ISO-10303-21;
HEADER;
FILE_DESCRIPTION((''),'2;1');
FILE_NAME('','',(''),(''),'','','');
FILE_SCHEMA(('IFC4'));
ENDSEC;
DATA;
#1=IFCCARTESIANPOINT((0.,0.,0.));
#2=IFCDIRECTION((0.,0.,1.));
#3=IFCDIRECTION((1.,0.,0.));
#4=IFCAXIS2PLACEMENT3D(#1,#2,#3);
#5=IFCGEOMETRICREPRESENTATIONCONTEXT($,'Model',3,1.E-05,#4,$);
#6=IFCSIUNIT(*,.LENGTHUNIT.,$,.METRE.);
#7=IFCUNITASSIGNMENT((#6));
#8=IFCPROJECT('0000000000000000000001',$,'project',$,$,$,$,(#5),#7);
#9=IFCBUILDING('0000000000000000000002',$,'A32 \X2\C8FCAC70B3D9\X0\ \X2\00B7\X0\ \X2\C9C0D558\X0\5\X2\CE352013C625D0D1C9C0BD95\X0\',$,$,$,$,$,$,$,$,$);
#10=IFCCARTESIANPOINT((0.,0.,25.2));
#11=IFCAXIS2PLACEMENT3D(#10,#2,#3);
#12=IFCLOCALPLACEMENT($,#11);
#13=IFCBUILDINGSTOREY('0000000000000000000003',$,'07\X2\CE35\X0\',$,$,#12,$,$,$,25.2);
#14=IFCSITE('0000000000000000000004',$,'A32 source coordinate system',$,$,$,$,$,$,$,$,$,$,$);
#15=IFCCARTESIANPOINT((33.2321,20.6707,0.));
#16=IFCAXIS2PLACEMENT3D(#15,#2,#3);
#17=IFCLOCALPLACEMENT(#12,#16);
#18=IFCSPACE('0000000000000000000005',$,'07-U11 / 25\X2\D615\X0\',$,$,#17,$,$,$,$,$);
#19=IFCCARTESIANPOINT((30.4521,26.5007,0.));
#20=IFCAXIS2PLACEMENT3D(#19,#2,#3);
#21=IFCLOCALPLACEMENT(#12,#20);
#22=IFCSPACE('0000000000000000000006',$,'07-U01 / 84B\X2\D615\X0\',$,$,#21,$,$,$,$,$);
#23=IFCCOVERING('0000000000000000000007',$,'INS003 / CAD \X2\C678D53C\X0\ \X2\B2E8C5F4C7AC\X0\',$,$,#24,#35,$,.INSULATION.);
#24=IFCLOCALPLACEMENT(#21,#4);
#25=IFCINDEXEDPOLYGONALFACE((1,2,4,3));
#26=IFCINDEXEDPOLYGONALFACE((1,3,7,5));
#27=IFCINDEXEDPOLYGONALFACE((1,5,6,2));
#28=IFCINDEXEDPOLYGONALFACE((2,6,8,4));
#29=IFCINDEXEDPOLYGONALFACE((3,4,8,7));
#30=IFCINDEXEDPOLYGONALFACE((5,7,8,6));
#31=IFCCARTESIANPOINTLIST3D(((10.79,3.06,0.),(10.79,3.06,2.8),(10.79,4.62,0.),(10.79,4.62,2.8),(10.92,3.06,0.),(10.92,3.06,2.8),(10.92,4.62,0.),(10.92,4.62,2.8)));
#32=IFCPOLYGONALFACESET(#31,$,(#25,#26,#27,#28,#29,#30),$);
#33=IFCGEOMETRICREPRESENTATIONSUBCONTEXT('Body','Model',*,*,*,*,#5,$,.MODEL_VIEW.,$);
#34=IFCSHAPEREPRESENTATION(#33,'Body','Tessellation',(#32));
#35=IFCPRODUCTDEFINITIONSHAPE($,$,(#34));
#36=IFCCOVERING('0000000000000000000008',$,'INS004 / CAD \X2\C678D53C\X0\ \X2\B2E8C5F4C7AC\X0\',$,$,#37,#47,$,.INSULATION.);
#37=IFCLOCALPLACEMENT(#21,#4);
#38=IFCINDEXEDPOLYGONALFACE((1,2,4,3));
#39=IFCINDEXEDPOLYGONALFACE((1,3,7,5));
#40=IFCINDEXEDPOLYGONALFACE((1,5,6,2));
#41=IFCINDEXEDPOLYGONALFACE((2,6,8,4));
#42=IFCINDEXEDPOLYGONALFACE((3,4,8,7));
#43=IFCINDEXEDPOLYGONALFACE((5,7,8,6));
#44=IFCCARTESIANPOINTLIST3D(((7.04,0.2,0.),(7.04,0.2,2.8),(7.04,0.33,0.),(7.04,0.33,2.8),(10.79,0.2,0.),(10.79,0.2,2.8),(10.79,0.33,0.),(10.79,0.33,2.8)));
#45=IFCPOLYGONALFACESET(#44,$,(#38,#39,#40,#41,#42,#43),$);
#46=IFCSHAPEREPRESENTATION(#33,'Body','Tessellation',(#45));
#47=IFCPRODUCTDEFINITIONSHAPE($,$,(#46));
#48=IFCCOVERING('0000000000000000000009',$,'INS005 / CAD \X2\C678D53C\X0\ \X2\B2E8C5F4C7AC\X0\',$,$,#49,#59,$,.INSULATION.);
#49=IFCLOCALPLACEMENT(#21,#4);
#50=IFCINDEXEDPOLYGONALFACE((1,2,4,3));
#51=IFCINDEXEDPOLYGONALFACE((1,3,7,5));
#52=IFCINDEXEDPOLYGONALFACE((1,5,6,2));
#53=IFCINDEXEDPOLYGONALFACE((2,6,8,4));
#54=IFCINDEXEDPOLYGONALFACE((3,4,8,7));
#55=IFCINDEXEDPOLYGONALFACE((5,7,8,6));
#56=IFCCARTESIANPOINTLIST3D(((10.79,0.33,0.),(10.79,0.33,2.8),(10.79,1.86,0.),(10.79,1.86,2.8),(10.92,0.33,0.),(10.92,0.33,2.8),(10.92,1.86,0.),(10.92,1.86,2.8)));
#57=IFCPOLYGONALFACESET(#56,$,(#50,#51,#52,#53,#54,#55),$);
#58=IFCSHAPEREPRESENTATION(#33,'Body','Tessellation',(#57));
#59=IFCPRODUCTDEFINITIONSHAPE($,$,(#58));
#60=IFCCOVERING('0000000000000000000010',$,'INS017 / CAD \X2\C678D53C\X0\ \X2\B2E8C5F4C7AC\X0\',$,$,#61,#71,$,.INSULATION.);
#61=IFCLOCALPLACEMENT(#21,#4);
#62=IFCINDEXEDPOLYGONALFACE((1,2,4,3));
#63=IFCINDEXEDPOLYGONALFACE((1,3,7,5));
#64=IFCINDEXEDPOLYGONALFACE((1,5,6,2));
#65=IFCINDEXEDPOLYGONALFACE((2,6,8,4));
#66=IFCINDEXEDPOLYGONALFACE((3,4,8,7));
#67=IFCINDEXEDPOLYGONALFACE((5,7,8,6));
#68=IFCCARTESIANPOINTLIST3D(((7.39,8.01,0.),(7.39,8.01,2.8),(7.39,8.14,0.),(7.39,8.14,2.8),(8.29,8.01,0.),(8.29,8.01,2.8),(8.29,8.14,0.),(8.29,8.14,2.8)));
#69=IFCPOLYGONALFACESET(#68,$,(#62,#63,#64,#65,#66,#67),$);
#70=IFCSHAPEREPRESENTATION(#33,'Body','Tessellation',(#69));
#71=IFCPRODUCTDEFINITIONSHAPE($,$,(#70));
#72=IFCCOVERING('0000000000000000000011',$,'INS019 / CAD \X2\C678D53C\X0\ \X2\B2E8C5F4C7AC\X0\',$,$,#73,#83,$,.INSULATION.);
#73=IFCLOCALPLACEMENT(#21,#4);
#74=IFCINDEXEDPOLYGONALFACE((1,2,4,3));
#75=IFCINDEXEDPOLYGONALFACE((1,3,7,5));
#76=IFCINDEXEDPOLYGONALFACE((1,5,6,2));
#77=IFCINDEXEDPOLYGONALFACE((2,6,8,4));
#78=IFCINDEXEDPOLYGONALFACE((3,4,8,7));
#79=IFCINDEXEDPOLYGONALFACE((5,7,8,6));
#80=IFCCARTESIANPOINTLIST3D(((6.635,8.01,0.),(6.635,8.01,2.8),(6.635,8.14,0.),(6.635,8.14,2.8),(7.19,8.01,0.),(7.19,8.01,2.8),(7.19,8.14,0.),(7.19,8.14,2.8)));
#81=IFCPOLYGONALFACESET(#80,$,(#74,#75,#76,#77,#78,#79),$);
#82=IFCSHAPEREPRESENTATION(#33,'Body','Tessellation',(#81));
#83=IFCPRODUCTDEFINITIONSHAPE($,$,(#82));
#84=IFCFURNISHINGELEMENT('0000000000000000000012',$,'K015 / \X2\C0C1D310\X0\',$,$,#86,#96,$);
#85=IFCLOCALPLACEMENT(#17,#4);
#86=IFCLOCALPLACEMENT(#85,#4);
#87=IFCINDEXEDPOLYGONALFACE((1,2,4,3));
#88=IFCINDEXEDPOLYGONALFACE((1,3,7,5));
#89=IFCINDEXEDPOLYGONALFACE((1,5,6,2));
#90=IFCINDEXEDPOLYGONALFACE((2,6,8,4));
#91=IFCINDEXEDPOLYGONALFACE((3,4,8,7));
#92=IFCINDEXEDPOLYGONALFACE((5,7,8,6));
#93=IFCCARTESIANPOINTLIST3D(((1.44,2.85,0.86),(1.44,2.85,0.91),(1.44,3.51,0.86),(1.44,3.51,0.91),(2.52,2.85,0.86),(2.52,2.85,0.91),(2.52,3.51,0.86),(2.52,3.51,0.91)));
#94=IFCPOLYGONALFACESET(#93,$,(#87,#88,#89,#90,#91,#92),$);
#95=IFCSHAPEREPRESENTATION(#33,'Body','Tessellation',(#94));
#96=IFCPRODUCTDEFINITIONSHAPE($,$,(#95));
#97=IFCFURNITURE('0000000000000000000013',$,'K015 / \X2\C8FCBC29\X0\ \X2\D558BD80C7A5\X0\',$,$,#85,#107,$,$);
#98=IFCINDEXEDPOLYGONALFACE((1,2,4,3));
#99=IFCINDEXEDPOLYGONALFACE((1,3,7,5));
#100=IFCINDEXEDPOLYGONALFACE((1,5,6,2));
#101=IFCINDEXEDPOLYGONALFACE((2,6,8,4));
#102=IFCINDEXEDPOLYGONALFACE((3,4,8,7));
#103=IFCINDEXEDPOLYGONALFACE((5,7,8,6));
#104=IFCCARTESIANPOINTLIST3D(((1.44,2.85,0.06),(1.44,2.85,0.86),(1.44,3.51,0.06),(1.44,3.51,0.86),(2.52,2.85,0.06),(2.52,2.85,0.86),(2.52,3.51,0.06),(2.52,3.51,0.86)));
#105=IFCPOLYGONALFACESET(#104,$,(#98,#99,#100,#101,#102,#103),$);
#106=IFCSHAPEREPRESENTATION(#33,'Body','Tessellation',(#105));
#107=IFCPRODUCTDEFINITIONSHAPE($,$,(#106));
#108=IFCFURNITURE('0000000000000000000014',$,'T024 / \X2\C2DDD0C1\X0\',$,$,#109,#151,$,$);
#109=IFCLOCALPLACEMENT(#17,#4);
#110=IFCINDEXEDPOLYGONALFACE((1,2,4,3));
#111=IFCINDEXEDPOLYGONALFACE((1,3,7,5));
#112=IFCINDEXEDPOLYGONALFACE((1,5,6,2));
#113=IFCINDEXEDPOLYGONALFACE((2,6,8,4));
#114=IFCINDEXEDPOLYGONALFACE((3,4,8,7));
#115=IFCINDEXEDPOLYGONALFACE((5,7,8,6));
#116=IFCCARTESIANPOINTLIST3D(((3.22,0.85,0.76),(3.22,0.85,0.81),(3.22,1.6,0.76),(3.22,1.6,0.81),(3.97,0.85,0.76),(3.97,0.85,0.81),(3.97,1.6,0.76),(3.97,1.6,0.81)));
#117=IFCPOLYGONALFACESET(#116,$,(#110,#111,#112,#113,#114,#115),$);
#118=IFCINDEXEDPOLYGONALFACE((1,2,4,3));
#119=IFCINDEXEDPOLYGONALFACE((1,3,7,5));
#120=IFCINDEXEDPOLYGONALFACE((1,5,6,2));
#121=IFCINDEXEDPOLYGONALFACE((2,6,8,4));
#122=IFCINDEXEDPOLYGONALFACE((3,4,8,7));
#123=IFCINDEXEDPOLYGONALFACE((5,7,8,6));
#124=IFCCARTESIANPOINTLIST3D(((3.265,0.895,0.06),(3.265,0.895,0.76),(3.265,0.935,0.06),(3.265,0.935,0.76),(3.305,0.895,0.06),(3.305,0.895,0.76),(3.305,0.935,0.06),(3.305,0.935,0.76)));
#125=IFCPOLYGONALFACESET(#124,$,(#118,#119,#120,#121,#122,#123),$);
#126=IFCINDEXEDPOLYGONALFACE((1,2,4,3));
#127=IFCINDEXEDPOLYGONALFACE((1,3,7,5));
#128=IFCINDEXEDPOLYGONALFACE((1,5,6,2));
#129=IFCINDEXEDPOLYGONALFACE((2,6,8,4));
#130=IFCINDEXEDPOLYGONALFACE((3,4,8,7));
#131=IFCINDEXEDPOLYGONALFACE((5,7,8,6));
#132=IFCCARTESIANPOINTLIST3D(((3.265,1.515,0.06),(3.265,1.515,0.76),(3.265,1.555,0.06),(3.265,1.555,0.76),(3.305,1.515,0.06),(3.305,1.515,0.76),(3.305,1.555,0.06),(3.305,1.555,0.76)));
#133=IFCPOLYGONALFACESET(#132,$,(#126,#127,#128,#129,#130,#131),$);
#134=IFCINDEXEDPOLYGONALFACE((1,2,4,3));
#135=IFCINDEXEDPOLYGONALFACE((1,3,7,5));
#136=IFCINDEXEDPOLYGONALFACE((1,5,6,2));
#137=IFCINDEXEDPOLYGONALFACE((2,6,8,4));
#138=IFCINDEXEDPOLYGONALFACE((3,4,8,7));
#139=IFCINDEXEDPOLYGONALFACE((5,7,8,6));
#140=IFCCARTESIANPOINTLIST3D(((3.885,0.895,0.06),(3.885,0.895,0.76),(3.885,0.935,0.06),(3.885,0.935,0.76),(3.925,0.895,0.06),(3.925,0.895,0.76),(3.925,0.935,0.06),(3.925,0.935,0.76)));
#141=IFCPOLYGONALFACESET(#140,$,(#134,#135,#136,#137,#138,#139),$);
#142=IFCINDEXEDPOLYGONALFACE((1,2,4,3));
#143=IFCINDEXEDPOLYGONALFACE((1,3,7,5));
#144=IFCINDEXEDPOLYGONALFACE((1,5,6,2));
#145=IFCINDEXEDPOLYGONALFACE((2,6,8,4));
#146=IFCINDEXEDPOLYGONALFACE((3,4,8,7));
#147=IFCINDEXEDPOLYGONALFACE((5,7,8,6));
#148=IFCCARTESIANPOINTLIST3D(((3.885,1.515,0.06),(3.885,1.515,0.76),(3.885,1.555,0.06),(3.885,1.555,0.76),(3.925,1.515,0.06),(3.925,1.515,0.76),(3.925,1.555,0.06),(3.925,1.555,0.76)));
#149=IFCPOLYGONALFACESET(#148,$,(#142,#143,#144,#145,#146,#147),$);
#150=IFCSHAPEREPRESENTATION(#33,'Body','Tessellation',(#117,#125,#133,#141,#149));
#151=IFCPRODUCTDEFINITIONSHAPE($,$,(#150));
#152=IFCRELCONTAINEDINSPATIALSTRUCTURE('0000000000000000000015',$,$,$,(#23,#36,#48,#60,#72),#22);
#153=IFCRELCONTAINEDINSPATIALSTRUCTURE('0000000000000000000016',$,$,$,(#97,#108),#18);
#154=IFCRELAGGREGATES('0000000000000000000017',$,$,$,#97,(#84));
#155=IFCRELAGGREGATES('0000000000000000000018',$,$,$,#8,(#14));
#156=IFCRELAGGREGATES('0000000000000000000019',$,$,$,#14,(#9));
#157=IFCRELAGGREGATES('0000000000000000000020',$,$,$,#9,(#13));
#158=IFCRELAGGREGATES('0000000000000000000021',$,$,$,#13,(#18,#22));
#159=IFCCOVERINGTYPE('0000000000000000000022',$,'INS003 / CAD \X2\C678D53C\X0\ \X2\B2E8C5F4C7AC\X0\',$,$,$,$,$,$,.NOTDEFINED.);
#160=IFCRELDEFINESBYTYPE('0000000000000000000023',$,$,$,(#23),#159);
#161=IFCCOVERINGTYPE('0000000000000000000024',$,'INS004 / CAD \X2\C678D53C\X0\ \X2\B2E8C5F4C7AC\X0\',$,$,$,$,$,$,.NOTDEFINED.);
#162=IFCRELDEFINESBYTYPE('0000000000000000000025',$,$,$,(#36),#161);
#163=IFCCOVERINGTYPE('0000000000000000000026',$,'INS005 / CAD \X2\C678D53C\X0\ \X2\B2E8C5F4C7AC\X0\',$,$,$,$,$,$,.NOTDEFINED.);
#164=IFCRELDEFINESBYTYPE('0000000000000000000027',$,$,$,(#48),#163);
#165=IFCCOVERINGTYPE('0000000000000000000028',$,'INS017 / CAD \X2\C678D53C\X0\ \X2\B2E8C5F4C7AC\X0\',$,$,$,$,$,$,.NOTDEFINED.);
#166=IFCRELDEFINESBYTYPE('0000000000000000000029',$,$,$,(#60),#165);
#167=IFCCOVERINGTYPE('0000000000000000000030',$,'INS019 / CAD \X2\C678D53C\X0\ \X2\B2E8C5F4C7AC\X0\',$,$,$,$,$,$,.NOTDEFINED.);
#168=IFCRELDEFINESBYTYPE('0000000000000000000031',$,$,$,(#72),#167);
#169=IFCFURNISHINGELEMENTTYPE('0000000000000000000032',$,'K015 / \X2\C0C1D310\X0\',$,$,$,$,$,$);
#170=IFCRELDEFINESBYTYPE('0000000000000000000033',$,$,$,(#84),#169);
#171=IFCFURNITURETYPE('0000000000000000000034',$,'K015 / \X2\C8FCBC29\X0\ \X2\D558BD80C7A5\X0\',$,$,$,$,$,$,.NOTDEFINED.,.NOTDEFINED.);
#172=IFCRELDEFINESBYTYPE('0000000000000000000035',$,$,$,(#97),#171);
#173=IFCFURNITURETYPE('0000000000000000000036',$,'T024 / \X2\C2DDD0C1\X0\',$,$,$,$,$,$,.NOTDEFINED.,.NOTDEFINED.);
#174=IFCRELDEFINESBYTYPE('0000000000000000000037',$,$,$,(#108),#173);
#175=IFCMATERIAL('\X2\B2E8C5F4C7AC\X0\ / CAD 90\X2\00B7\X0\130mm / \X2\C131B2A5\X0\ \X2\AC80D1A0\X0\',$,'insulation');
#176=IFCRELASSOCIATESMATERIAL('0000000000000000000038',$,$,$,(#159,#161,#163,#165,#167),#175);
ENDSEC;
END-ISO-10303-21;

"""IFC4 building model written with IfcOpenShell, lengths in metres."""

from ifc_helpers import new_model, si_unit, frame, origin, origin_with_axes, place, context, subcontext, project, spatial, polyline, outline, extrude, source, transform, mapped, material, type_object, type_shapes, element, aggregate, save


model = new_model("IFC4")

# Units and contexts
model_context = context("Model", 3, precision=1e-05, world=origin_with_axes())
body_context = subcontext(model_context, "Body", "Model", "MODEL_VIEW")
ifc_project = project(units=[si_unit("LENGTHUNIT", "METRE")], contexts=[model_context])

# Site, building, storey, space
site = spatial("IfcSite", under=ifc_project, Name="A32 source coordinate system")
building = spatial("IfcBuilding", under=site, Name="A32 주거동 · 지하5층–옥탑지붕")
storey_placement = place(None, frame((0.0, 0.0, 25.2), z_axis=(0.0, 0.0, 1.0), x_axis=(1.0, 0.0, 0.0)))
storey = spatial("IfcBuildingStorey", under=building, at=storey_placement, Name="07층", Elevation=25.2)
space_1_placement = place(storey_placement, frame((33.2321, 20.6707, 0.0), z_axis=(0.0, 0.0, 1.0), x_axis=(1.0, 0.0, 0.0)))
space_1 = spatial("IfcSpace", under=storey, at=space_1_placement, Name="07-U11 / 25형")

# Shared definitions
space_2_placement = place(storey_placement, frame((30.4521, 26.5007, 0.0), z_axis=(0.0, 0.0, 1.0), x_axis=(1.0, 0.0, 0.0)))
space_2 = spatial("IfcSpace", under=storey, at=space_2_placement, Name="07-U01 / 84B형")

# Coverings
ifc_material = material(Name="단열재 / CAD 90·130mm / 성능 검토", Category="insulation")
covering_type_1 = type_object("IfcCoveringType", Name="INS003 / CAD 외피 단열재", PredefinedType="NOTDEFINED", material=ifc_material)
shared_shape_1 = source(origin(), body_context, "Body", "SweptSolid", [
    extrude(outline(polyline([(10.79, 3.06), (10.79, 4.62), (10.92, 4.62), (10.92, 3.06), (10.79, 3.06)])), origin(), (0.0, 0.0, 1.0), 2.8),
])
type_shapes(covering_type_1, [shared_shape_1])
covering_1_placement = place(space_2_placement, origin_with_axes())
element("IfcCovering", 1, at=covering_1_placement, inside=space_2, type_object=covering_type_1, Name="INS003 / CAD 외피 단열재", PredefinedType="INSULATION", context=body_context, shape_type="MappedRepresentation", body=[
    mapped(shared_shape_1, transform((0.0, 0.0, 0.0), scale=1.0)),
])
covering_type_2 = type_object("IfcCoveringType", Name="INS004 / CAD 외피 단열재", PredefinedType="NOTDEFINED", material=ifc_material)
shared_shape_2 = source(origin(), body_context, "Body", "SweptSolid", [
    extrude(outline(polyline([(7.04, 0.33), (10.79, 0.33), (10.79, 0.2), (7.04, 0.2), (7.04, 0.33)])), origin(), (0.0, 0.0, 1.0), 2.8),
])
type_shapes(covering_type_2, [shared_shape_2])
covering_2_placement = place(space_2_placement, origin_with_axes())
element("IfcCovering", 2, at=covering_2_placement, inside=space_2, type_object=covering_type_2, Name="INS004 / CAD 외피 단열재", PredefinedType="INSULATION", context=body_context, shape_type="MappedRepresentation", body=[
    mapped(shared_shape_2, transform((0.0, 0.0, 0.0), scale=1.0)),
])
covering_type_3 = type_object("IfcCoveringType", Name="INS005 / CAD 외피 단열재", PredefinedType="NOTDEFINED", material=ifc_material)
shared_shape_3 = source(origin(), body_context, "Body", "SweptSolid", [
    extrude(outline(polyline([(10.79, 0.33), (10.79, 1.86), (10.92, 1.86), (10.92, 0.33), (10.79, 0.33)])), origin(), (0.0, 0.0, 1.0), 2.8),
])
type_shapes(covering_type_3, [shared_shape_3])
covering_3_placement = place(space_2_placement, origin_with_axes())
element("IfcCovering", 3, at=covering_3_placement, inside=space_2, type_object=covering_type_3, Name="INS005 / CAD 외피 단열재", PredefinedType="INSULATION", context=body_context, shape_type="MappedRepresentation", body=[
    mapped(shared_shape_3, transform((0.0, 0.0, 0.0), scale=1.0)),
])
covering_type_4 = type_object("IfcCoveringType", Name="INS017 / CAD 외피 단열재", PredefinedType="NOTDEFINED", material=ifc_material)
shared_shape_4 = source(origin(), body_context, "Body", "SweptSolid", [
    extrude(outline(polyline([(8.29, 8.01), (7.39, 8.01), (7.39, 8.14), (8.29, 8.14), (8.29, 8.01)])), origin(), (0.0, 0.0, 1.0), 2.8),
])
type_shapes(covering_type_4, [shared_shape_4])
covering_4_placement = place(space_2_placement, origin_with_axes())
element("IfcCovering", 4, at=covering_4_placement, inside=space_2, type_object=covering_type_4, Name="INS017 / CAD 외피 단열재", PredefinedType="INSULATION", context=body_context, shape_type="MappedRepresentation", body=[
    mapped(shared_shape_4, transform((0.0, 0.0, 0.0), scale=1.0)),
])
covering_type_5 = type_object("IfcCoveringType", Name="INS019 / CAD 외피 단열재", PredefinedType="NOTDEFINED", material=ifc_material)
shared_shape_5 = source(origin(), body_context, "Body", "SweptSolid", [
    extrude(outline(polyline([(6.635, 8.01), (6.635, 8.14), (7.19, 8.14), (7.19, 8.01), (6.635, 8.01)])), origin(), (0.0, 0.0, 1.0), 2.8),
])
type_shapes(covering_type_5, [shared_shape_5])
covering_5_placement = place(space_2_placement, origin_with_axes())
element("IfcCovering", 5, at=covering_5_placement, inside=space_2, type_object=covering_type_5, Name="INS019 / CAD 외피 단열재", PredefinedType="INSULATION", context=body_context, shape_type="MappedRepresentation", body=[
    mapped(shared_shape_5, transform((0.0, 0.0, 0.0), scale=1.0)),
])

# Furnishing element
furnishing_element_type_1 = type_object("IfcFurnishingElementType", Name="K015 / 상판")
shared_shape_6 = source(origin(), body_context, "Body", "SweptSolid", [
    extrude(outline(polyline([(2.52, 2.85), (1.44, 2.85), (1.44, 3.51), (2.52, 3.51), (2.52, 2.85)])), frame((0.0, 0.0, 0.86)), (0.0, 0.0, 1.0), 0.05),
])
type_shapes(furnishing_element_type_1, [shared_shape_6])
furniture_1_placement = place(space_1_placement, origin_with_axes())
furnishing_1_placement = place(furniture_1_placement, origin_with_axes())
furnishing_1 = element("IfcFurnishingElement", 6, at=furnishing_1_placement, type_object=furnishing_element_type_1, Name="K015 / 상판", context=body_context, shape_type="MappedRepresentation", body=[
    mapped(shared_shape_6, transform((0.0, 0.0, 0.0), scale=1.0)),
])

# Furniture
furniture_type_1 = type_object("IfcFurnitureType", Name="K015 / 주방 하부장", AssemblyPlace="NOTDEFINED", PredefinedType="NOTDEFINED")
shared_shape_7 = source(origin(), body_context, "Body", "SweptSolid", [
    extrude(outline(polyline([(2.52, 3.51), (2.52, 2.85), (1.44, 2.85), (1.44, 3.51), (2.52, 3.51)])), frame((0.0, 0.0, 0.06)), (0.0, 0.0, 1.0), 0.8),
])
type_shapes(furniture_type_1, [shared_shape_7])
furniture_1 = element("IfcFurniture", 7, at=furniture_1_placement, inside=space_1, type_object=furniture_type_1, Name="K015 / 주방 하부장", context=body_context, shape_type="MappedRepresentation", body=[
    mapped(shared_shape_7, transform((0.0, 0.0, 0.0), scale=1.0)),
])
aggregate(furniture_1, [furnishing_1])
furniture_type_2 = type_object("IfcFurnitureType", Name="T024 / 식탁", AssemblyPlace="NOTDEFINED", PredefinedType="NOTDEFINED")
shared_shape_8 = source(origin(), body_context, "Body", "SweptSolid", [
    extrude(outline(polyline([(3.22, 0.85), (3.22, 1.6), (3.97, 1.6), (3.97, 0.85), (3.22, 0.85)])), frame((0.0, 0.0, 0.76)), (0.0, 0.0, 1.0), 0.05),
    extrude(outline(polyline([(3.265, 0.895), (3.265, 0.935), (3.305, 0.935), (3.305, 0.895), (3.265, 0.895)])), frame((0.0, 0.0, 0.06)), (0.0, 0.0, 1.0), 0.7),
    extrude(outline(polyline([(3.265, 1.515), (3.265, 1.555), (3.305, 1.555), (3.305, 1.515), (3.265, 1.515)])), frame((0.0, 0.0, 0.06)), (0.0, 0.0, 1.0), 0.7),
    extrude(outline(polyline([(3.885, 0.895), (3.885, 0.935), (3.925, 0.935), (3.925, 0.895), (3.885, 0.895)])), frame((0.0, 0.0, 0.06)), (0.0, 0.0, 1.0), 0.7),
    extrude(outline(polyline([(3.885, 1.515), (3.885, 1.555), (3.925, 1.555), (3.925, 1.515), (3.885, 1.515)])), frame((0.0, 0.0, 0.06)), (0.0, 0.0, 1.0), 0.7),
])
type_shapes(furniture_type_2, [shared_shape_8])
furniture_2_placement = place(space_1_placement, origin_with_axes())
element("IfcFurniture", 8, at=furniture_2_placement, inside=space_1, type_object=furniture_type_2, Name="T024 / 식탁", context=body_context, shape_type="MappedRepresentation", body=[
    mapped(shared_shape_8, transform((0.0, 0.0, 0.0), scale=1.0)),
])

save(model, "model.ifc")
